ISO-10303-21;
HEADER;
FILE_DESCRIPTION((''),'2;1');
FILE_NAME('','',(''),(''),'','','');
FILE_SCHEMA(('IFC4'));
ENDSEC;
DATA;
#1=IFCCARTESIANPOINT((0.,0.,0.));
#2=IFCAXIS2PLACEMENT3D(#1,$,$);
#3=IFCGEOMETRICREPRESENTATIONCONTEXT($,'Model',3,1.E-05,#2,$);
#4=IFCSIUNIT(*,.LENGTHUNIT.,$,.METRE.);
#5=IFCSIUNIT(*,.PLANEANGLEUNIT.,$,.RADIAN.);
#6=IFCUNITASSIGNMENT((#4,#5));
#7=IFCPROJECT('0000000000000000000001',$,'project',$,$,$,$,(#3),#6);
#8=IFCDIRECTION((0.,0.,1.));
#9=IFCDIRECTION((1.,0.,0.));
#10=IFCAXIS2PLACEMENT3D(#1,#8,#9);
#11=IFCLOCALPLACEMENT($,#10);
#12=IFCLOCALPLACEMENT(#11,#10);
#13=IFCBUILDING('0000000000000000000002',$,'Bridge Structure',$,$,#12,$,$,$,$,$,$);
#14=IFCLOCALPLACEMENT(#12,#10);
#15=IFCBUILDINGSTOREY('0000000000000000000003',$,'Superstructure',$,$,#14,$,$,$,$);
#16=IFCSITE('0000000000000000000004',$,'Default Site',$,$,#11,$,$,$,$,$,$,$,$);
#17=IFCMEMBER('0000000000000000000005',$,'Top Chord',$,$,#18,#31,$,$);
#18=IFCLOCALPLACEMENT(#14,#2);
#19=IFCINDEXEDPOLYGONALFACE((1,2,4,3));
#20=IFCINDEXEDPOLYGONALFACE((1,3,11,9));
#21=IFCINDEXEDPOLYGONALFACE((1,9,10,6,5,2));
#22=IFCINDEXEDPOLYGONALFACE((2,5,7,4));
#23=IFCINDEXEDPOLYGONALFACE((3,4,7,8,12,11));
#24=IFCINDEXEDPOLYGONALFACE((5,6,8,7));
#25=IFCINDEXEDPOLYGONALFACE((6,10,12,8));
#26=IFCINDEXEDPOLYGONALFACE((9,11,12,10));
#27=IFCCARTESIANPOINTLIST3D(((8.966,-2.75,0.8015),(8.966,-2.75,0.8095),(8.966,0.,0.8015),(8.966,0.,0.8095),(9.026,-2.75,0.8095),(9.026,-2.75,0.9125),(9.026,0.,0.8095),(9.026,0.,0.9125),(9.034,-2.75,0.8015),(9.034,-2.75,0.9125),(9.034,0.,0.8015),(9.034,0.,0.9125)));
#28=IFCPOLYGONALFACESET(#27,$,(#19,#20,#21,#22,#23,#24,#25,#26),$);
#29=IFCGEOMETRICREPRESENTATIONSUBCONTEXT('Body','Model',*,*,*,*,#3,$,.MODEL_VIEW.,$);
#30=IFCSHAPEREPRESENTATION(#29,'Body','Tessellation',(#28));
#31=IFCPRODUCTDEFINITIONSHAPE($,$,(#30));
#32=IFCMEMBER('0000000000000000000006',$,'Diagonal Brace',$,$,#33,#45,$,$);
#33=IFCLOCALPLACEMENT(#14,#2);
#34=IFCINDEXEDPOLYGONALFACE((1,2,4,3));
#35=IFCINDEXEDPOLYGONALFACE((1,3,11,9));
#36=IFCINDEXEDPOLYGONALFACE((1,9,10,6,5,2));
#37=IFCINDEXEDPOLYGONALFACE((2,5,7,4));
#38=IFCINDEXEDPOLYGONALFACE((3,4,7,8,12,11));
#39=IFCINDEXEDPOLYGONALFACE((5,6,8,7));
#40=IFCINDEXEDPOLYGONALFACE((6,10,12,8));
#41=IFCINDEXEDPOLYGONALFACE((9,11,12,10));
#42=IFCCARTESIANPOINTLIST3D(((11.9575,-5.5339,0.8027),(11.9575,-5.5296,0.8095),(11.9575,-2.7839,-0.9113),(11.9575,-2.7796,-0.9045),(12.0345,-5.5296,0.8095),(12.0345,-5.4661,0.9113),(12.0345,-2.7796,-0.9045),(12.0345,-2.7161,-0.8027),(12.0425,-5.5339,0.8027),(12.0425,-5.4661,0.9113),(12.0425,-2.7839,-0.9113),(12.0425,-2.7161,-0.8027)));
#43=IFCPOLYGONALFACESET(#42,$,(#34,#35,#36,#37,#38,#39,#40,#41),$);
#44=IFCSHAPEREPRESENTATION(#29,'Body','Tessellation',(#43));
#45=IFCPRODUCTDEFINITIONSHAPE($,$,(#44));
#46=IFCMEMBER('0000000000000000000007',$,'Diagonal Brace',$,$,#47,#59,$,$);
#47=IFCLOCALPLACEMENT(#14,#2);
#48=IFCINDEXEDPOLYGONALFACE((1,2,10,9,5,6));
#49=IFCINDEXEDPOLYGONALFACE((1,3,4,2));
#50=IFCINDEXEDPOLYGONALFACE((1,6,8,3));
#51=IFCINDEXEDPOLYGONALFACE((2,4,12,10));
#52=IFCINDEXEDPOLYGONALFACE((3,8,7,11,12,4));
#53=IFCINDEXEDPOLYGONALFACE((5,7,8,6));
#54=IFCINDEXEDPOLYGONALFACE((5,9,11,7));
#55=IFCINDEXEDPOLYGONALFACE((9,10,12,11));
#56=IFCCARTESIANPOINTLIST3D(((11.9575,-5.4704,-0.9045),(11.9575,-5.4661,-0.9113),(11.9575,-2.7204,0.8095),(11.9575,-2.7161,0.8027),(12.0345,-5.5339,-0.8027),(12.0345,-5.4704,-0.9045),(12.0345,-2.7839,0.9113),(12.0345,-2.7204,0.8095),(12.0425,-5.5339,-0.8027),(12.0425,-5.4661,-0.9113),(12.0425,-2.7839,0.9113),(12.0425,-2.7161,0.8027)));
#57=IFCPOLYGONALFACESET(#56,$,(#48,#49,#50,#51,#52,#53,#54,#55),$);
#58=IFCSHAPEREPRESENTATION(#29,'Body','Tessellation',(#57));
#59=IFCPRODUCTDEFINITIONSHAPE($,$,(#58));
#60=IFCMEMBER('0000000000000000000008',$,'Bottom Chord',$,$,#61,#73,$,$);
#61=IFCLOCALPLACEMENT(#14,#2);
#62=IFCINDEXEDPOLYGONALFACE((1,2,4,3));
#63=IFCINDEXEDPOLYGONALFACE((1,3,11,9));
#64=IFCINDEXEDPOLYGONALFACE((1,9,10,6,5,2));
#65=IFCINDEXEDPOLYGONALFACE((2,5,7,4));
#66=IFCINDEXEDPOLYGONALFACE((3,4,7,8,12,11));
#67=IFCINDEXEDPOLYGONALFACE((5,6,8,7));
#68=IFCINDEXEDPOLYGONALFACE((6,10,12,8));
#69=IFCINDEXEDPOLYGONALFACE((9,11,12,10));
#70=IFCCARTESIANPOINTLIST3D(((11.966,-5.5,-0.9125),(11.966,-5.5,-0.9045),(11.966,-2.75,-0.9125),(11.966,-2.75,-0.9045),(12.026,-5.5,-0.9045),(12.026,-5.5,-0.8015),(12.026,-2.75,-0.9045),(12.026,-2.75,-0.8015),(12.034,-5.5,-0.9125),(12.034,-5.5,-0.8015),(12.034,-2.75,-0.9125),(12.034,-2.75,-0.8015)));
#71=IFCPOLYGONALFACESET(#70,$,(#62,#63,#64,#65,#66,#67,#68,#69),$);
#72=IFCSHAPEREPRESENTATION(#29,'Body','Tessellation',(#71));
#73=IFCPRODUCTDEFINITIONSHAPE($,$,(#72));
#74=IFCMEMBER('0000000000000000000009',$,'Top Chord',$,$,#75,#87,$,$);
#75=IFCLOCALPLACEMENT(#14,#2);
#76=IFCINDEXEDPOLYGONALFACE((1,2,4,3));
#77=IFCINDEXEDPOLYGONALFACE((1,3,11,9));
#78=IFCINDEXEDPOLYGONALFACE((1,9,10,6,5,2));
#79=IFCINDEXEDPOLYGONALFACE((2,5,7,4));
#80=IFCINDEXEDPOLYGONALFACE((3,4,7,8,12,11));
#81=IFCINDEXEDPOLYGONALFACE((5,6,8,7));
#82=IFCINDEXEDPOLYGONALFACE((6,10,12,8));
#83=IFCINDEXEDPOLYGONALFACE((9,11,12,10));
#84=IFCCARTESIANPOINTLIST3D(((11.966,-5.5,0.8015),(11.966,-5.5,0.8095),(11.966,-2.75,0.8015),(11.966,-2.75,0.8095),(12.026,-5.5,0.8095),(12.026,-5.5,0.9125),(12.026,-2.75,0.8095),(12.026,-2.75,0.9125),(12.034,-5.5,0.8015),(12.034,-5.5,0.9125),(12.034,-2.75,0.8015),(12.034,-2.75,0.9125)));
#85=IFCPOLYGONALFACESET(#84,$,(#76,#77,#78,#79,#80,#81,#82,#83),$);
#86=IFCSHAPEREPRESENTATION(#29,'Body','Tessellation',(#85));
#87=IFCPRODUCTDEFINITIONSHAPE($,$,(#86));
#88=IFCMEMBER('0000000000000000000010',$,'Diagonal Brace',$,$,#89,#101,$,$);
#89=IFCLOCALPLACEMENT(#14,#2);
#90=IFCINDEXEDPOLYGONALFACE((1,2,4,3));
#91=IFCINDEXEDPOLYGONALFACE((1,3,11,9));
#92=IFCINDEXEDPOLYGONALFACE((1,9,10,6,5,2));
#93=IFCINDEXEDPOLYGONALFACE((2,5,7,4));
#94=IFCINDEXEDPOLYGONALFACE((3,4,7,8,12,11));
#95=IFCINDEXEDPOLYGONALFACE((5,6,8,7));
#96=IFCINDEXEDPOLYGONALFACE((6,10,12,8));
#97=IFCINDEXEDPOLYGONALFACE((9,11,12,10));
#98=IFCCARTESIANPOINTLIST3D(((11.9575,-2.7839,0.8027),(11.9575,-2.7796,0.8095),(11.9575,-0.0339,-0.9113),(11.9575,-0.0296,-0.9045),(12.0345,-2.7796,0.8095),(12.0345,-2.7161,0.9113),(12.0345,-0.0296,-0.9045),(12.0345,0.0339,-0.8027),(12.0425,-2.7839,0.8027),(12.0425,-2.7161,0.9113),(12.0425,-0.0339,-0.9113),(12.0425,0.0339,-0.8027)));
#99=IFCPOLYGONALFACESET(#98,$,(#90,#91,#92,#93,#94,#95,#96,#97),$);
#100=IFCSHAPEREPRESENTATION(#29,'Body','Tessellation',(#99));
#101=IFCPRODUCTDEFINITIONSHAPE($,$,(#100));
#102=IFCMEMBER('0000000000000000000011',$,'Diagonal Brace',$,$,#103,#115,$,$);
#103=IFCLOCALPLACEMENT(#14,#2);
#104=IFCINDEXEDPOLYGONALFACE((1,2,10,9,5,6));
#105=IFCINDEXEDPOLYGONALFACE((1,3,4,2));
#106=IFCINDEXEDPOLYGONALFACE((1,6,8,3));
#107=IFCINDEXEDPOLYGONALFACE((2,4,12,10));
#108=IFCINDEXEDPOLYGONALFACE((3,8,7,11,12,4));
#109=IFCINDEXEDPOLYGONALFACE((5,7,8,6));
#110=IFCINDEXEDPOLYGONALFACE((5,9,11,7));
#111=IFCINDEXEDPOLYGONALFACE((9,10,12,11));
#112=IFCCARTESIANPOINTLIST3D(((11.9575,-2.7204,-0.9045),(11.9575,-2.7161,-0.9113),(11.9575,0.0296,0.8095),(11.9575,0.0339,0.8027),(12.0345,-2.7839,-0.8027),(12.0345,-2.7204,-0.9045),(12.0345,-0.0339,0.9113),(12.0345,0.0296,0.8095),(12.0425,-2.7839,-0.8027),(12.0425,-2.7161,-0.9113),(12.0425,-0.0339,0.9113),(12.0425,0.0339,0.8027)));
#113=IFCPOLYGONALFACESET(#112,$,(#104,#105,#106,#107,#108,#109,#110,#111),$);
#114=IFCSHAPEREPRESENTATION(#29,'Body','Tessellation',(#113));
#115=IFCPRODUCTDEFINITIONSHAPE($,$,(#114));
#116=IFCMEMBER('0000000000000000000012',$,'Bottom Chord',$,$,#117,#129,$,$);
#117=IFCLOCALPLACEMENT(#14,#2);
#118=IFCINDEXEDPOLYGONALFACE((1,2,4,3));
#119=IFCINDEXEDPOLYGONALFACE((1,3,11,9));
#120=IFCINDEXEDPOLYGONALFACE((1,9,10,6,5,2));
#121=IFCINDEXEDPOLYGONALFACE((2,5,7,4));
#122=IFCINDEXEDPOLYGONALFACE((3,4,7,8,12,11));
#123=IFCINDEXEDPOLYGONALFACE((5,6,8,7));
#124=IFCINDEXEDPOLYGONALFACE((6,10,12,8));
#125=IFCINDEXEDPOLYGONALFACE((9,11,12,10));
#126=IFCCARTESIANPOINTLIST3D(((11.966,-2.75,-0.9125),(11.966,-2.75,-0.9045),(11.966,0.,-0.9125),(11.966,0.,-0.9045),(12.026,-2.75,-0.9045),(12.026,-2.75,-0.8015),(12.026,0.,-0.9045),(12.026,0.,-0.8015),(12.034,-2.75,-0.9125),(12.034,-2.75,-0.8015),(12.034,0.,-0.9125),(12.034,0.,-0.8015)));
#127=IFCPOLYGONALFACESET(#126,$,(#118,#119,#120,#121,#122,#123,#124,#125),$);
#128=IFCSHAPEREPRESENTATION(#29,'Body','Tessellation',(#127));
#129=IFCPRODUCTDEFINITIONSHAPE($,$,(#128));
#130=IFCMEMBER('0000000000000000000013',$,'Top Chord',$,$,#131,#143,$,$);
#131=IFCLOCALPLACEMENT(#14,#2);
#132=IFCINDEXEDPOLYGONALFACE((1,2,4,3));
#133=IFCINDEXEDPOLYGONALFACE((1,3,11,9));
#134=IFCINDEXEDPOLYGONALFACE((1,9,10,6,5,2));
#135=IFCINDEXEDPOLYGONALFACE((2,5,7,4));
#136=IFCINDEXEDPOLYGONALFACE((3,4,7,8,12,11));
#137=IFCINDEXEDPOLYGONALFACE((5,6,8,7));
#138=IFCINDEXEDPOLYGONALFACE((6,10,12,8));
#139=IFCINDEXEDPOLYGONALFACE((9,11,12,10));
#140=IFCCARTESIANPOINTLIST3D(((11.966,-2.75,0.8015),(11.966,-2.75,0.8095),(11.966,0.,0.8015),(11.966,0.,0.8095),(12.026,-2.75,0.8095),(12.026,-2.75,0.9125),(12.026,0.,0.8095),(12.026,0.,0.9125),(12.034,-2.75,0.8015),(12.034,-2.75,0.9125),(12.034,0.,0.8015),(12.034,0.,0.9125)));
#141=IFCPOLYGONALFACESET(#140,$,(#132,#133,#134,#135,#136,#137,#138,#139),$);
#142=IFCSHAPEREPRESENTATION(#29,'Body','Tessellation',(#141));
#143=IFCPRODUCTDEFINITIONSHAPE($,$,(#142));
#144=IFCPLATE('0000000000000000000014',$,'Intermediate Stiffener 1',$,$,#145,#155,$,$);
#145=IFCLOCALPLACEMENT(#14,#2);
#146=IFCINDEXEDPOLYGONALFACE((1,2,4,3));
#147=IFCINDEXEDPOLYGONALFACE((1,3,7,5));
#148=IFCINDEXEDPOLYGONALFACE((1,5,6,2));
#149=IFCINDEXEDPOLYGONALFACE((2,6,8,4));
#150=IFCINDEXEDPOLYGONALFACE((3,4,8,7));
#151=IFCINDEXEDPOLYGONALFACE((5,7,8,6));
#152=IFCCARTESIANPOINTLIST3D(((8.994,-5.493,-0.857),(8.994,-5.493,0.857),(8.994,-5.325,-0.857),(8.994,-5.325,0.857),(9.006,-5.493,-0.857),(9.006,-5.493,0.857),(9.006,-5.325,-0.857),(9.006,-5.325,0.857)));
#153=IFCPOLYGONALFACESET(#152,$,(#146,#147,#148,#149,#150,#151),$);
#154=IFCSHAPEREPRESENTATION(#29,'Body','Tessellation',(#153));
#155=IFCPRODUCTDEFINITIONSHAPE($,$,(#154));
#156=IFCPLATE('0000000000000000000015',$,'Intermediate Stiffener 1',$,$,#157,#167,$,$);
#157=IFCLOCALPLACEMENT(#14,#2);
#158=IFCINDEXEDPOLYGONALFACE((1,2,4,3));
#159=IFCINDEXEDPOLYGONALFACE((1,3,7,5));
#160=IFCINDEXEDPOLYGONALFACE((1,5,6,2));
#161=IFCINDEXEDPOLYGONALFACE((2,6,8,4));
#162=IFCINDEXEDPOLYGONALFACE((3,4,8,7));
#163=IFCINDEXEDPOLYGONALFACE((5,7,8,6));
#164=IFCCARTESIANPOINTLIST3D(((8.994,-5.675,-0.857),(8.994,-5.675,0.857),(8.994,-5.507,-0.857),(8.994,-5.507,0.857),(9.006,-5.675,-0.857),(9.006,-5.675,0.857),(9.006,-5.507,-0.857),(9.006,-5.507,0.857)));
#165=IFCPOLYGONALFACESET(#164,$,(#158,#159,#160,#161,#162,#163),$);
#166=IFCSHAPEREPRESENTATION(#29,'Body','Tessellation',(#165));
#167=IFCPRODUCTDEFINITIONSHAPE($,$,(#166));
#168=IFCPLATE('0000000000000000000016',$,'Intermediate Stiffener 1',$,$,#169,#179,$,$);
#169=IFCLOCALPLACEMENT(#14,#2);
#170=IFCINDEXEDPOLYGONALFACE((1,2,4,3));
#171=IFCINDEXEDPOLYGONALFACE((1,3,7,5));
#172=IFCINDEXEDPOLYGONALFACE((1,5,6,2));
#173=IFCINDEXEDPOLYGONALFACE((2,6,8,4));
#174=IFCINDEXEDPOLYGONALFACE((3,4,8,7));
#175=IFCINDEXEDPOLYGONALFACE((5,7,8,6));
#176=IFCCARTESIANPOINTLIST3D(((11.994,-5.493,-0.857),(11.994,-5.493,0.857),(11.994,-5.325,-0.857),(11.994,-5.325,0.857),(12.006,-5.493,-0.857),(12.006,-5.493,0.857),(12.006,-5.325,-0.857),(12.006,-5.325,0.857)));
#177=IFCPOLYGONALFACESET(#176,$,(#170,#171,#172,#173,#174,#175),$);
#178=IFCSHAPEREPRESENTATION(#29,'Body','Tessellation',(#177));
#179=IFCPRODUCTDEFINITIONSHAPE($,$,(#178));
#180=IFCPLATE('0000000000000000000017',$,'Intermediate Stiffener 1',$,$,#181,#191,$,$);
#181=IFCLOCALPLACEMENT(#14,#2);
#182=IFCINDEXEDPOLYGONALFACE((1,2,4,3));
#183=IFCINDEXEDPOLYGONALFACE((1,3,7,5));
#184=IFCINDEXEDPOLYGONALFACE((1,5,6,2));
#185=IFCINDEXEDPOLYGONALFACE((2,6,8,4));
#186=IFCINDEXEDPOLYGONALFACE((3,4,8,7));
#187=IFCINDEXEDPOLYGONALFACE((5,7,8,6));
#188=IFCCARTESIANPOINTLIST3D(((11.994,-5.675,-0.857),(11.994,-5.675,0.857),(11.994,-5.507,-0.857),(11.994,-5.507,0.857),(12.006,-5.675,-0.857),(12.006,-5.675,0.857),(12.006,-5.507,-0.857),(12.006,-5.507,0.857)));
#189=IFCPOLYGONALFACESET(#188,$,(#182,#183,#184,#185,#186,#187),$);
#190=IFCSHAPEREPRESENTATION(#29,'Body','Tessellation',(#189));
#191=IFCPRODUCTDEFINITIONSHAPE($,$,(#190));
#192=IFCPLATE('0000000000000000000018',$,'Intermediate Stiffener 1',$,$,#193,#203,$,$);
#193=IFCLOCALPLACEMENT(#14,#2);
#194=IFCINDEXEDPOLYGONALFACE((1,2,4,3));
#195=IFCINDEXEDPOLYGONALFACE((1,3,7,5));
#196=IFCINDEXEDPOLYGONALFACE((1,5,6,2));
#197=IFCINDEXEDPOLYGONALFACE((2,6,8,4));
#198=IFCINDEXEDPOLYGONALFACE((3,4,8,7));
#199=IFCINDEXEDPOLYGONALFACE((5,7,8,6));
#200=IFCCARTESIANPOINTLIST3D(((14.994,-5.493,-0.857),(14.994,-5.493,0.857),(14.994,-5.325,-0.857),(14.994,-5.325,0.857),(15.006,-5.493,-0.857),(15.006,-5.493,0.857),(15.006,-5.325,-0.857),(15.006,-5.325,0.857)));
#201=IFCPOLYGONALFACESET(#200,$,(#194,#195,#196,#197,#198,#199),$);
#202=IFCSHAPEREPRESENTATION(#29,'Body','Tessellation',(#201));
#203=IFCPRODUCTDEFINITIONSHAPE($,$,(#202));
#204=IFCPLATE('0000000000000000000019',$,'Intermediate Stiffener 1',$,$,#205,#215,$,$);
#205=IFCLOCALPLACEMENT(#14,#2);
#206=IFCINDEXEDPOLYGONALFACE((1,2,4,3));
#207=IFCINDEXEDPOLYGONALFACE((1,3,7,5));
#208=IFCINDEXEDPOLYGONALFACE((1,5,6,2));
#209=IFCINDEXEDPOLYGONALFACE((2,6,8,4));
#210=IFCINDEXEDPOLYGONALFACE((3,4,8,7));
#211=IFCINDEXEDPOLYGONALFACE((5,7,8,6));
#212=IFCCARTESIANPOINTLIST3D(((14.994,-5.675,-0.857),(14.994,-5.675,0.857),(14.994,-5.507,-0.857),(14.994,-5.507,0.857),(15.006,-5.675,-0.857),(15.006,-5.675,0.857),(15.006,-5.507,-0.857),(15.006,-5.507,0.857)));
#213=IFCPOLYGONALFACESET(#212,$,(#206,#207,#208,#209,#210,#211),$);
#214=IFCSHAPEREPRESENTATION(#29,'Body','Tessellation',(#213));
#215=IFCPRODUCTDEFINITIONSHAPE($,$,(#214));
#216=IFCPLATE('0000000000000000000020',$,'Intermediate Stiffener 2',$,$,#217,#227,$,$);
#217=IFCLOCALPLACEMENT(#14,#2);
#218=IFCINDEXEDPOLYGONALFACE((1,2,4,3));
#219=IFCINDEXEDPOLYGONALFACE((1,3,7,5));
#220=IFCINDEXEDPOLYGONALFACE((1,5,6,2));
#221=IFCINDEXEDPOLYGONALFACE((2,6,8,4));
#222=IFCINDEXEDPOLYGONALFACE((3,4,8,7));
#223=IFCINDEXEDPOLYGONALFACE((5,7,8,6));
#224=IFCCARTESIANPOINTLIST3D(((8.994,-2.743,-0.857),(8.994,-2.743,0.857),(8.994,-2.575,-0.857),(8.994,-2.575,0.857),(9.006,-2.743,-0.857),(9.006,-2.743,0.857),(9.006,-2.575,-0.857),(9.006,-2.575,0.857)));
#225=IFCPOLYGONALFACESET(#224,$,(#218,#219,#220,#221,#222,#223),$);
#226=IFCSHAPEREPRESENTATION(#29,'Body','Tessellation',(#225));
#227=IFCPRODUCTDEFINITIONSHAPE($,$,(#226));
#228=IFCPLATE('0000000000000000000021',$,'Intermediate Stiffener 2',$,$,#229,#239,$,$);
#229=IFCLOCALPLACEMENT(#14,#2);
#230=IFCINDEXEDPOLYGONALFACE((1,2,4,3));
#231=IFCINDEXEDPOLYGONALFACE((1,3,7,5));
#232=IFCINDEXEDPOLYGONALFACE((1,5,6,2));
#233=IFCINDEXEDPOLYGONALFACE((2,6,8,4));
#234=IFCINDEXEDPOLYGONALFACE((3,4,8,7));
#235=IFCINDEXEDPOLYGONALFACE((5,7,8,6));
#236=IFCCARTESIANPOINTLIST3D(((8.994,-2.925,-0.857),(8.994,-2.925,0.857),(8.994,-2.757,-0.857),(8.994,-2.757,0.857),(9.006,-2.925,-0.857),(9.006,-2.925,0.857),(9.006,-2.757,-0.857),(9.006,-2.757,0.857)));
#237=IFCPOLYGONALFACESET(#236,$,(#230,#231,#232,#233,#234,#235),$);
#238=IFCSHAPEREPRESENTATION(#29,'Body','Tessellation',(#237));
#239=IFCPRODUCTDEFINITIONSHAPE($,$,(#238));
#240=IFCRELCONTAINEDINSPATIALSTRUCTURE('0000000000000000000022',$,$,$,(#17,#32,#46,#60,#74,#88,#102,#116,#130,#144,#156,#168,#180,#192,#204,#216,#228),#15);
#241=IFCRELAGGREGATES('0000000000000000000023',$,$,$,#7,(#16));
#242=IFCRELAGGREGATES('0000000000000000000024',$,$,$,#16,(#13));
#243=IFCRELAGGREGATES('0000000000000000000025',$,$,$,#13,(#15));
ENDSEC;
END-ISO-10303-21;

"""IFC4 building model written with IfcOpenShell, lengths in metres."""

from ifc_helpers import new_model, si_unit, frame, origin, origin_with_axes, origin_2d_with_axis, place, context, subcontext, project, spatial, rectangle, l_section, extrude, element, save


model = new_model("IFC4")

# Units and contexts
model_context = context("Model", 3, precision=1e-05, world=origin())
body_context = subcontext(model_context, "Body", "Model", "MODEL_VIEW")
ifc_project = project(units=[si_unit("LENGTHUNIT", "METRE"), si_unit("PLANEANGLEUNIT", "RADIAN")], contexts=[model_context])

# Site, building, storey
site_placement = place(None, origin_with_axes())
site = spatial("IfcSite", under=ifc_project, at=site_placement, Name="Default Site")
building_placement = place(site_placement, origin_with_axes())
building = spatial("IfcBuilding", under=site, at=building_placement, Name="Bridge Structure")
storey_placement = place(building_placement, origin_with_axes())
storey = spatial("IfcBuildingStorey", under=building, at=storey_placement, Name="Superstructure")

# Members
for number, where, z_axis, x_axis, name in (
    (1, (9.0, -2.75, 0.857), (0.0, 1.0, 0.0), (-1.0, 0.0, 0.0), "Top Chord"),
):
    element("IfcMember", number, at=place(storey_placement, frame(where, z_axis=z_axis, x_axis=x_axis)), inside=storey, Name=name, context=body_context, shape_type="SweptSolid", body=[
        extrude(l_section(Depth=0.111, Width=0.068, Thickness=0.008, at=origin_2d_with_axis()), origin_with_axes(), (0.0, 0.0, 1.0), 2.75),
    ])
for number, where, z_axis, x_axis, name in (
    (2, (12.0, -5.5, 0.857), (0.0, 0.848656, -0.528944), (-1.0, 0.0, 0.0), "Diagonal Brace"),
    (3, (12.0, -5.5, -0.857), (0.0, 0.848656, 0.528944), (-1.0, 0.0, 0.0), "Diagonal Brace"),
):
    element("IfcMember", number, at=place(storey_placement, frame(where, z_axis=z_axis, x_axis=x_axis)), inside=storey, Name=name, context=body_context, shape_type="SweptSolid", body=[
        extrude(l_section(Depth=0.128, Width=0.085, Thickness=0.008, at=origin_2d_with_axis()), origin_with_axes(), (0.0, 0.0, 1.0), 3.2404),
    ])
for number, where, z_axis, x_axis, name in (
    (4, (12.0, -5.5, -0.857), (0.0, 1.0, 0.0), (-1.0, 0.0, 0.0), "Bottom Chord"),
    (5, (12.0, -5.5, 0.857), (0.0, 1.0, 0.0), (-1.0, 0.0, 0.0), "Top Chord"),
):
    element("IfcMember", number, at=place(storey_placement, frame(where, z_axis=z_axis, x_axis=x_axis)), inside=storey, Name=name, context=body_context, shape_type="SweptSolid", body=[
        extrude(l_section(Depth=0.111, Width=0.068, Thickness=0.008, at=origin_2d_with_axis()), origin_with_axes(), (0.0, 0.0, 1.0), 2.75),
    ])
for number, where, z_axis, x_axis, name in (
    (6, (12.0, -2.75, 0.857), (0.0, 0.848656, -0.528944), (-1.0, 0.0, 0.0), "Diagonal Brace"),
    (7, (12.0, -2.75, -0.857), (0.0, 0.848656, 0.528944), (-1.0, 0.0, 0.0), "Diagonal Brace"),
):
    element("IfcMember", number, at=place(storey_placement, frame(where, z_axis=z_axis, x_axis=x_axis)), inside=storey, Name=name, context=body_context, shape_type="SweptSolid", body=[
        extrude(l_section(Depth=0.128, Width=0.085, Thickness=0.008, at=origin_2d_with_axis()), origin_with_axes(), (0.0, 0.0, 1.0), 3.2404),
    ])
for number, where, z_axis, x_axis, name in (
    (8, (12.0, -2.75, -0.857), (0.0, 1.0, 0.0), (-1.0, 0.0, 0.0), "Bottom Chord"),
    (9, (12.0, -2.75, 0.857), (0.0, 1.0, 0.0), (-1.0, 0.0, 0.0), "Top Chord"),
):
    element("IfcMember", number, at=place(storey_placement, frame(where, z_axis=z_axis, x_axis=x_axis)), inside=storey, Name=name, context=body_context, shape_type="SweptSolid", body=[
        extrude(l_section(Depth=0.111, Width=0.068, Thickness=0.008, at=origin_2d_with_axis()), origin_with_axes(), (0.0, 0.0, 1.0), 2.75),
    ])

# Plates
for number, where, z_axis, x_axis, name in (
    (10, (9.0, -5.409, -0.857), (0.0, 0.0, 1.0), (1.0, 0.0, 0.0), "Intermediate Stiffener 1"),
    (11, (9.0, -5.591, -0.857), (0.0, 0.0, 1.0), (1.0, 0.0, 0.0), "Intermediate Stiffener 1"),
    (12, (12.0, -5.409, -0.857), (0.0, 0.0, 1.0), (1.0, 0.0, 0.0), "Intermediate Stiffener 1"),
    (13, (12.0, -5.591, -0.857), (0.0, 0.0, 1.0), (1.0, 0.0, 0.0), "Intermediate Stiffener 1"),
    (14, (15.0, -5.409, -0.857), (0.0, 0.0, 1.0), (1.0, 0.0, 0.0), "Intermediate Stiffener 1"),
    (15, (15.0, -5.591, -0.857), (0.0, 0.0, 1.0), (1.0, 0.0, 0.0), "Intermediate Stiffener 1"),
    (16, (9.0, -2.659, -0.857), (0.0, 0.0, 1.0), (1.0, 0.0, 0.0), "Intermediate Stiffener 2"),
    (17, (9.0, -2.841, -0.857), (0.0, 0.0, 1.0), (1.0, 0.0, 0.0), "Intermediate Stiffener 2"),
):
    element("IfcPlate", number, at=place(storey_placement, frame(where, z_axis=z_axis, x_axis=x_axis)), inside=storey, Name=name, context=body_context, shape_type="SweptSolid", body=[
        extrude(rectangle(XDim=0.012, YDim=0.168, at=origin_2d_with_axis()), origin_with_axes(), (0.0, 0.0, 1.0), 1.714),
    ])

save(model, "model.ifc")
